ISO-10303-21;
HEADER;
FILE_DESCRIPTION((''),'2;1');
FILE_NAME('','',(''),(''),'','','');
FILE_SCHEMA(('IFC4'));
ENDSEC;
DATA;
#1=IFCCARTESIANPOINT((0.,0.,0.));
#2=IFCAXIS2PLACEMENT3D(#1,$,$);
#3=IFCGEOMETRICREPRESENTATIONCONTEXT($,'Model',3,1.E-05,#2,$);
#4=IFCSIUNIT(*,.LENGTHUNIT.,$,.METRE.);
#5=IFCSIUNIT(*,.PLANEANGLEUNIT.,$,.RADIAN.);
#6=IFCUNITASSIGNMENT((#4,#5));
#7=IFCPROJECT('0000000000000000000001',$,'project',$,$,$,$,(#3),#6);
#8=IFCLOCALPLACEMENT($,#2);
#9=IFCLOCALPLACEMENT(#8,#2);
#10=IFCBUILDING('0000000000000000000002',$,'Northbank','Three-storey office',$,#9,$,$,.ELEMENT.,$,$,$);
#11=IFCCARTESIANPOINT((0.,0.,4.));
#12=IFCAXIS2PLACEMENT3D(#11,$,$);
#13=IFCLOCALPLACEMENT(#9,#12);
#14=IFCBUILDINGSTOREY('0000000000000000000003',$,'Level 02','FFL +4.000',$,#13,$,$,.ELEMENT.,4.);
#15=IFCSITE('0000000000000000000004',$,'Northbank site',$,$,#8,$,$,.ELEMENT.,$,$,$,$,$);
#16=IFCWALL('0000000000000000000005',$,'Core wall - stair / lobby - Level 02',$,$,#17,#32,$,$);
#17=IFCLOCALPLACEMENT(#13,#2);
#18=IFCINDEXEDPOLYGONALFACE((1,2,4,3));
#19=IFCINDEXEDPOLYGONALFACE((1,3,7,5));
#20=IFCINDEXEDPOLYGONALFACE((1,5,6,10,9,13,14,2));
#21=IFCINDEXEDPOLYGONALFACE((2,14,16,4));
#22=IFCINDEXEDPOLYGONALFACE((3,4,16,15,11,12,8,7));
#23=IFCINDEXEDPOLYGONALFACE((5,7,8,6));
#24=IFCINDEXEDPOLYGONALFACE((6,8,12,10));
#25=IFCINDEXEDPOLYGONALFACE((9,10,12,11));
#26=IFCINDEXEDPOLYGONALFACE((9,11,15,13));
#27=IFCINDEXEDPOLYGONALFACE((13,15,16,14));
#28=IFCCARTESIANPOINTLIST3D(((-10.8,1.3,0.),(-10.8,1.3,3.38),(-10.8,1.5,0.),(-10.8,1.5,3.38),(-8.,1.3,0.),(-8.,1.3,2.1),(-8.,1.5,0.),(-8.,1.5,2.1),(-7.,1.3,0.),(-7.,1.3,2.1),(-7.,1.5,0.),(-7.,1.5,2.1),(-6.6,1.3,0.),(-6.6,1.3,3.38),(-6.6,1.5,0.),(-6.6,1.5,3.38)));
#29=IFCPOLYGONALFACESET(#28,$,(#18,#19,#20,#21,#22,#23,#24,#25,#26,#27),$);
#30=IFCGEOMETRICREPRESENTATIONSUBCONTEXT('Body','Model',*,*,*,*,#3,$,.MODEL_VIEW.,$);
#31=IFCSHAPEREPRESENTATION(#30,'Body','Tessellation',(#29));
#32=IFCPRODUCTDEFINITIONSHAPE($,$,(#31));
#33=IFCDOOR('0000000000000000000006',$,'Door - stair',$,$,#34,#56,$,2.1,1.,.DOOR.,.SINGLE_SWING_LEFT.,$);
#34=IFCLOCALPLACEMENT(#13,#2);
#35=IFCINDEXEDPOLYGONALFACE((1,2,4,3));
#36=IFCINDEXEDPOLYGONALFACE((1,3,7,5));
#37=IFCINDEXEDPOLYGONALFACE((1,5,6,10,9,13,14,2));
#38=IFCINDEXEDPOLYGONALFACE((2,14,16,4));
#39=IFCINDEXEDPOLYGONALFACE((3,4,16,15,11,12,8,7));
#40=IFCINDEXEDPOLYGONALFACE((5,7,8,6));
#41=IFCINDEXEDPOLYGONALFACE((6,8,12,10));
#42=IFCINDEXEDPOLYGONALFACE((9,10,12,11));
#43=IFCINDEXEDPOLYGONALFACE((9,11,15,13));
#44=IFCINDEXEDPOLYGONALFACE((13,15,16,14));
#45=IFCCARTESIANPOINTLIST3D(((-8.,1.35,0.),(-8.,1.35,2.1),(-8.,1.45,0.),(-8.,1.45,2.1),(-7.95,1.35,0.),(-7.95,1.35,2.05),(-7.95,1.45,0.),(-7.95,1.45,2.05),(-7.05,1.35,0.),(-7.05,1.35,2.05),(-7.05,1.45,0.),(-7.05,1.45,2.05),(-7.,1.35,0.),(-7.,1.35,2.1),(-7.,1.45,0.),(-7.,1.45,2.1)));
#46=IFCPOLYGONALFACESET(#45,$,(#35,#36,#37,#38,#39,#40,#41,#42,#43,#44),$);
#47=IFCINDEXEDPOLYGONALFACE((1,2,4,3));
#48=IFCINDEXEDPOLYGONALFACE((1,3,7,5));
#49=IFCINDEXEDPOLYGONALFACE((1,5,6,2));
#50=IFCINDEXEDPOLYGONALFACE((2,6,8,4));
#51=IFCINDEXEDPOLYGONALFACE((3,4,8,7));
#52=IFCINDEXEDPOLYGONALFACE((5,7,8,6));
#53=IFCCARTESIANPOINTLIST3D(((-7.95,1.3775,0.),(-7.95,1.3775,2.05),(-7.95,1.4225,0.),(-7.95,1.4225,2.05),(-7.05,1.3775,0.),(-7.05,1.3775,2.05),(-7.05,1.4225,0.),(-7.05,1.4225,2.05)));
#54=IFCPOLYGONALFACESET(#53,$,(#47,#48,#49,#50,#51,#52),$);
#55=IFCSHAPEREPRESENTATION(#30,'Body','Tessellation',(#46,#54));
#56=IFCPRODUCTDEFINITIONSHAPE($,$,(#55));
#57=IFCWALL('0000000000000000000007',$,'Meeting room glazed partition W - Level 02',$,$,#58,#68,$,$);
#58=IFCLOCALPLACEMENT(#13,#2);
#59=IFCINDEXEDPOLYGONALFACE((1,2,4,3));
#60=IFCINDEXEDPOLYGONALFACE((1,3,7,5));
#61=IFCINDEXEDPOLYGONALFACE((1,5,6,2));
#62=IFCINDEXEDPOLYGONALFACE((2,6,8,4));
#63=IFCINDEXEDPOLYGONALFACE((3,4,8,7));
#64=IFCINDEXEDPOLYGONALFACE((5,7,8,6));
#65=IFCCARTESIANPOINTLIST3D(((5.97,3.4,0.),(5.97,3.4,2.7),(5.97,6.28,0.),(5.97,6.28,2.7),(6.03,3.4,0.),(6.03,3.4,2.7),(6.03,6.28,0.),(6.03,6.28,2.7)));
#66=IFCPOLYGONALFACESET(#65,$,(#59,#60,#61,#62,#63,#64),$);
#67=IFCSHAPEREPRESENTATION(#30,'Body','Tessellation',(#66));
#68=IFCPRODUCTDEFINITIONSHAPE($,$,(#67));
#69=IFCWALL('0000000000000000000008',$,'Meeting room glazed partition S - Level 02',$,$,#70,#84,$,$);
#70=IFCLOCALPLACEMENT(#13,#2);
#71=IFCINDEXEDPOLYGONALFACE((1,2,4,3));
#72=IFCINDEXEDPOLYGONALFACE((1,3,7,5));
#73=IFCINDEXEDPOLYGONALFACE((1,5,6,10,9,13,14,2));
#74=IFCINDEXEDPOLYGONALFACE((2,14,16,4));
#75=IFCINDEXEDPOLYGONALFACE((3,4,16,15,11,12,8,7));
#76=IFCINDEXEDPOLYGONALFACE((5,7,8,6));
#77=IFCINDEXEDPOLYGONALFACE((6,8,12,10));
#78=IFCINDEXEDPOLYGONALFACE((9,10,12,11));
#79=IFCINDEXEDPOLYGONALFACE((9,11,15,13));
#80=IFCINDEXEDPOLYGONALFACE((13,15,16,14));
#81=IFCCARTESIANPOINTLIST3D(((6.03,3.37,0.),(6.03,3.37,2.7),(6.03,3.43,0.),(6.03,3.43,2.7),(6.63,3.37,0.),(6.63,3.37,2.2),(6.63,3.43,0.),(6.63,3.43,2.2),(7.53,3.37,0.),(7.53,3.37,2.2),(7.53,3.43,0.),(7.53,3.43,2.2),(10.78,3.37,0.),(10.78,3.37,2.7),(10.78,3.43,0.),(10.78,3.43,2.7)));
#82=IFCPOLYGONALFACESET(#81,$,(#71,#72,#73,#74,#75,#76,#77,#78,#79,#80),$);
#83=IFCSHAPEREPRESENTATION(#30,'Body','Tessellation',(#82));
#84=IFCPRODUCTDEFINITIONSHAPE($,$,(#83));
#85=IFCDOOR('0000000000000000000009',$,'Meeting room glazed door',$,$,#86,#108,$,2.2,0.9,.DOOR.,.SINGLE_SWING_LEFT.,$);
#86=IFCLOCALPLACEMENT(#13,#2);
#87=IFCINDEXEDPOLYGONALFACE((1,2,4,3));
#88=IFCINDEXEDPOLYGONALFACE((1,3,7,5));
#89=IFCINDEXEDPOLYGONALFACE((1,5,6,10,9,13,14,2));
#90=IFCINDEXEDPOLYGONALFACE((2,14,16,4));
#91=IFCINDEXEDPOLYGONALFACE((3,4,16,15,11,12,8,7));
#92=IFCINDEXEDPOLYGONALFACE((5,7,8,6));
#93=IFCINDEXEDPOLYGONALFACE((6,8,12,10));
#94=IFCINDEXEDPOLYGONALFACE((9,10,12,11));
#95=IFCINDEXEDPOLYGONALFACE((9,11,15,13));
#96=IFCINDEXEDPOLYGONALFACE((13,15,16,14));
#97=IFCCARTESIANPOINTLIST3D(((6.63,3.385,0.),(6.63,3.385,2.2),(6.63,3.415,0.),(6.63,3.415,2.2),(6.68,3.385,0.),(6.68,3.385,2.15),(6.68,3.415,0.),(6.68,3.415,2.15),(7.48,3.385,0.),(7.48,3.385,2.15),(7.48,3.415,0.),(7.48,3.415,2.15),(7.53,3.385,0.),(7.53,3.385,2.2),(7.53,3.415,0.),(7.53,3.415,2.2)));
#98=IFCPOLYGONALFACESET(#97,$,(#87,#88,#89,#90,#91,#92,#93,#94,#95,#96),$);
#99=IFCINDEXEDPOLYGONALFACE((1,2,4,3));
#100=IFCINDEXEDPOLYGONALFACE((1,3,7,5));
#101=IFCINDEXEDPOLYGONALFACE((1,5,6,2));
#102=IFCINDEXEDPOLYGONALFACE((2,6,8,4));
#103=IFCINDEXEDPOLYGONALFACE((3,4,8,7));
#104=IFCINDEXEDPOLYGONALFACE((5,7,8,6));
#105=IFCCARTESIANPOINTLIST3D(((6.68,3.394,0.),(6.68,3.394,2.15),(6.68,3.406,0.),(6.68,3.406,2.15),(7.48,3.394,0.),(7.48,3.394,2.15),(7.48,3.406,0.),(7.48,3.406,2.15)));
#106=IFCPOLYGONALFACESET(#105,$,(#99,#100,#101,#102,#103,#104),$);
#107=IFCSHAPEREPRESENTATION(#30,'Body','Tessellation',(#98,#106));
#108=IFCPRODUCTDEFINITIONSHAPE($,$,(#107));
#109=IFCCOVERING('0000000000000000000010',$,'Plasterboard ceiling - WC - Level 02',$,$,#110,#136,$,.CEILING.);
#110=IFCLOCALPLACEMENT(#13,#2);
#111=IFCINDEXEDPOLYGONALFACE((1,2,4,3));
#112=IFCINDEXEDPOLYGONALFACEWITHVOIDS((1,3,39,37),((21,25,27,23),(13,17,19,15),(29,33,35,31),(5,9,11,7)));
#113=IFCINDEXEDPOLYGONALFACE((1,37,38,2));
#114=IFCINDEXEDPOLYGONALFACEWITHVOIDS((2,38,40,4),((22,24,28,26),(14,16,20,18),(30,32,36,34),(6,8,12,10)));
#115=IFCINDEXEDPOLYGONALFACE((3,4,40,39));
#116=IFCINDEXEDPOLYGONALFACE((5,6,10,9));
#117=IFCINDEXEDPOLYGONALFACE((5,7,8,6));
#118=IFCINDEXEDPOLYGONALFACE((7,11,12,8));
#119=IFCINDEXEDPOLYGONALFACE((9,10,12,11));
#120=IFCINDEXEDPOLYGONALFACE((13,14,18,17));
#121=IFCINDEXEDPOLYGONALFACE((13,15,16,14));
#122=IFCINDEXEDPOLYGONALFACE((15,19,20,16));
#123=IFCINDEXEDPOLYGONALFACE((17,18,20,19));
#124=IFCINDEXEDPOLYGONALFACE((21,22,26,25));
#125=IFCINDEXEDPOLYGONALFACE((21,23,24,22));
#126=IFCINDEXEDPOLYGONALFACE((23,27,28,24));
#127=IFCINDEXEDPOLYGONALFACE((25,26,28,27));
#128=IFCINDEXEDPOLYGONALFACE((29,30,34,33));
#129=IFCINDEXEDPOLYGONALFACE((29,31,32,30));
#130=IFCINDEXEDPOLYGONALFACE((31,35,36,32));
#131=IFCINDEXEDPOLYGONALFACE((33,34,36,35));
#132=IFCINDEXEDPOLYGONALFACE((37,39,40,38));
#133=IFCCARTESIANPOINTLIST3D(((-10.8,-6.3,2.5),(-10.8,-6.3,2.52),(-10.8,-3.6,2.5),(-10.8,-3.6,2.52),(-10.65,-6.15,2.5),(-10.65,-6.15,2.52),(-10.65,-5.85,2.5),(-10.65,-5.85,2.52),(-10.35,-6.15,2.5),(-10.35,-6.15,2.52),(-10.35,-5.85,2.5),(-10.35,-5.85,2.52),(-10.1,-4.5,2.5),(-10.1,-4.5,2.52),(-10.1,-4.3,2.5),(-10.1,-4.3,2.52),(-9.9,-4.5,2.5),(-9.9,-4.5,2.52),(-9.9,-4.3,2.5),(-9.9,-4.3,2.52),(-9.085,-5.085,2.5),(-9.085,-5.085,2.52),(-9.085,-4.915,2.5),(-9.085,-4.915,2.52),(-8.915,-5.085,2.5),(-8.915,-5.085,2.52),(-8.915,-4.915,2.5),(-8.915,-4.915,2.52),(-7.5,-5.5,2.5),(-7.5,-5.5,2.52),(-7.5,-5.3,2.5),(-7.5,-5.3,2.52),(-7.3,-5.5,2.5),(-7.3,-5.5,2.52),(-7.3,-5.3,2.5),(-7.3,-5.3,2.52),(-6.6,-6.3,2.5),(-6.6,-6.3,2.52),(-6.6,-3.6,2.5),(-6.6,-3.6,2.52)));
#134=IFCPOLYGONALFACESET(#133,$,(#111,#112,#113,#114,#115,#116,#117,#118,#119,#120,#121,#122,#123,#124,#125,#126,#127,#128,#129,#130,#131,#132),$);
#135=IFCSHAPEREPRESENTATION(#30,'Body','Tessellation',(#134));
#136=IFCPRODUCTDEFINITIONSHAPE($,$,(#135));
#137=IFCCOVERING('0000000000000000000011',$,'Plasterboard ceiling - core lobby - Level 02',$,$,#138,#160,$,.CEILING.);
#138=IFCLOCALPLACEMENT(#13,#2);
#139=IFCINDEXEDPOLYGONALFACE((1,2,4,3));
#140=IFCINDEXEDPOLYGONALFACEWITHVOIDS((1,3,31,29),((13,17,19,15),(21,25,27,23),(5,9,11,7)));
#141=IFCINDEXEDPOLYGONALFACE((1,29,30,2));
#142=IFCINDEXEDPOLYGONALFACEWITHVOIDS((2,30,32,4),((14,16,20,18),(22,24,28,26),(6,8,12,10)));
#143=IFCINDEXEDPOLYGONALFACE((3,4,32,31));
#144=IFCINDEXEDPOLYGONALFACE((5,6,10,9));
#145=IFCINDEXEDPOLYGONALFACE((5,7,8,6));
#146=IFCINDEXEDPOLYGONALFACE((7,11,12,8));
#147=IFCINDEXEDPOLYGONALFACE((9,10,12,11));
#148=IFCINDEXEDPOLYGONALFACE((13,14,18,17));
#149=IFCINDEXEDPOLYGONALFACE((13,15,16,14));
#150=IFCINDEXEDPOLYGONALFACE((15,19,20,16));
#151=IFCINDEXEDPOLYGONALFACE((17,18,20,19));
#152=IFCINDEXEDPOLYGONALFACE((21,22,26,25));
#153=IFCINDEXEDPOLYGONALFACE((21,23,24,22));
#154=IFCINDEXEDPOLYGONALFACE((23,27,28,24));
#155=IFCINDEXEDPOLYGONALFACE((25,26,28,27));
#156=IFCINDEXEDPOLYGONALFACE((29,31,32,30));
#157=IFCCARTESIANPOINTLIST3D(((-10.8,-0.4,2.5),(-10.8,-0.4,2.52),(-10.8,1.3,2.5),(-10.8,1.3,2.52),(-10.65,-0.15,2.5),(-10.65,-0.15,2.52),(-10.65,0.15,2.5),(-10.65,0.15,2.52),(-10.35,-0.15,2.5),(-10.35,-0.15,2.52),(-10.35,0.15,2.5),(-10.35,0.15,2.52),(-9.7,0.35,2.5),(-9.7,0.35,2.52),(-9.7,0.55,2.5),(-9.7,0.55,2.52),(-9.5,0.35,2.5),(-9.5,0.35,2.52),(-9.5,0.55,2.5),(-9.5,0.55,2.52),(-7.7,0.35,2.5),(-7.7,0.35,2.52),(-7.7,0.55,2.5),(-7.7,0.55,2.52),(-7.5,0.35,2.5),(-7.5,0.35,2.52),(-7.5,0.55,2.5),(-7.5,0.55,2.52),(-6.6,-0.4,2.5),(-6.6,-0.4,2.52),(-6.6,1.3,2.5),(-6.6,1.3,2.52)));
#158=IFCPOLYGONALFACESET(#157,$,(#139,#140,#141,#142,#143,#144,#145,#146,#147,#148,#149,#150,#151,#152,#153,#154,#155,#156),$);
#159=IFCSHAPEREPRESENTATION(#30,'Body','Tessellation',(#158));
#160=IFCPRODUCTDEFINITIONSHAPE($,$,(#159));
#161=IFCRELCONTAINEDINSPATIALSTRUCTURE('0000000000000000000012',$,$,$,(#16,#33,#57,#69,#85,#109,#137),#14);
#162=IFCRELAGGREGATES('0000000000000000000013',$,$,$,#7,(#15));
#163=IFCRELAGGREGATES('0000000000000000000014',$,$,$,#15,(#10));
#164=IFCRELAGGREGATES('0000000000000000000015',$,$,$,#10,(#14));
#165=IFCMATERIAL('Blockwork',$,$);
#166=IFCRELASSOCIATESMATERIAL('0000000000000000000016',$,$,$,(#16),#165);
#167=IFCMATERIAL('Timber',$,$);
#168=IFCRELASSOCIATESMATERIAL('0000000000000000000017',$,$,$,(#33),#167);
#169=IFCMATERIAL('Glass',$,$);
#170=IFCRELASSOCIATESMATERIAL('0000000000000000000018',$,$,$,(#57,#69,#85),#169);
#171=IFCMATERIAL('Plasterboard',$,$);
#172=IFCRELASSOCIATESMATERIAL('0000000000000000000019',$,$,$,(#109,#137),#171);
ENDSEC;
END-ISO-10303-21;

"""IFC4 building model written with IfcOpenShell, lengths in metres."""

from ifc_helpers import new_model, si_unit, frame, origin, place, context, subcontext, project, spatial, polyline, outline, extrude, material, element, fill, save


model = new_model("IFC4")

# Units and contexts
model_context = context("Model", 3, precision=1e-05, world=origin())
body_context = subcontext(model_context, "Body", "Model", "MODEL_VIEW")
ifc_project = project(units=[si_unit("LENGTHUNIT", "METRE"), si_unit("PLANEANGLEUNIT", "RADIAN")], contexts=[model_context])

# Site, building, storey
site_placement = place(None, origin())
site = spatial("IfcSite", under=ifc_project, at=site_placement, Name="Northbank site", CompositionType="ELEMENT")
building_placement = place(site_placement, origin())
building = spatial("IfcBuilding", under=site, at=building_placement, Name="Northbank", Description="Three-storey office", CompositionType="ELEMENT")
storey_placement = place(building_placement, frame((0.0, 0.0, 4.0)))
storey = spatial("IfcBuildingStorey", under=building, at=storey_placement, Name="Level 02", Description="FFL +4.000", CompositionType="ELEMENT", Elevation=4.0)

# Wall, opening, door
ifc_material_1 = material(Name="Blockwork")
wall_1_placement = place(storey_placement, frame((0.0, 0.0, -4.0)))
wall_1 = element("IfcWall", 1, at=wall_1_placement, inside=storey, material=ifc_material_1, Name="Core wall - stair / lobby - Level 02", context=body_context, shape_type="SweptSolid", body=[
    extrude(outline(polyline([(0.0, 0.0), (2.8, 0.0), (2.8, 2.1), (3.8, 2.1), (3.8, 0.0), (4.2, 0.0), (4.2, 3.38), (0.0, 3.38), (0.0, 0.0)])), frame((-10.8, 1.5, 4.0), z_axis=(0.0, -1.0, 0.0), x_axis=(1.0, 0.0, 0.0)), (0.0, 0.0, 1.0), 0.2),
])
opening_1_placement = place(storey_placement, frame((0.0, 0.0, -4.0)))
opening_1 = element("IfcOpeningElement", 2, at=opening_1_placement, cuts=wall_1, PredefinedType="OPENING", context=body_context, shape_type="SweptSolid", body=[
    extrude(outline(polyline([(0.0, 0.0), (1.0, 0.0), (1.0, 2.1), (0.0, 2.1), (0.0, 0.0)])), frame((-8.0, 1.55, 4.0), z_axis=(0.0, -1.0, 0.0), x_axis=(1.0, 0.0, 0.0)), (0.0, 0.0, 1.0), 0.3),
])
ifc_material_2 = material(Name="Timber")
door_1_placement = place(storey_placement, frame((0.0, 0.0, -4.0)))
door_1 = element("IfcDoor", 3, at=door_1_placement, inside=storey, material=ifc_material_2, Name="Door - stair", OperationType="SINGLE_SWING_LEFT", OverallHeight=2.1, OverallWidth=1.0, PredefinedType="DOOR", context=body_context, shape_type="SweptSolid", body=[
    extrude(outline(polyline([(0.0, 0.0), (0.05, 0.0), (0.05, 2.05), (0.95, 2.05), (0.95, 0.0), (1.0, 0.0), (1.0, 2.1), (0.0, 2.1), (0.0, 0.0)])), frame((-8.0, 1.45, 4.0), z_axis=(0.0, -1.0, 0.0), x_axis=(1.0, 0.0, 0.0)), (0.0, 0.0, 1.0), 0.1),
    extrude(outline(polyline([(0.0, 0.0), (0.9, 0.0), (0.9, 2.05), (0.0, 2.05), (0.0, 0.0)])), frame((-7.95, 1.4225, 4.0), z_axis=(0.0, -1.0, 0.0), x_axis=(1.0, 0.0, 0.0)), (0.0, 0.0, 1.0), 0.045),
])
fill(opening_1, door_1)

# Wall
ifc_material_3 = material(Name="Glass")
wall_2_placement = place(storey_placement, frame((0.0, 0.0, -4.0)))
element("IfcWall", 4, at=wall_2_placement, inside=storey, material=ifc_material_3, Name="Meeting room glazed partition W - Level 02", context=body_context, shape_type="SweptSolid", body=[
    extrude(outline(polyline([(0.0, 0.0), (2.88, 0.0), (2.88, 2.7), (0.0, 2.7), (0.0, 0.0)])), frame((5.97, 3.4, 4.0), z_axis=(1.0, 0.0, 0.0), x_axis=(0.0, 1.0, 0.0)), (0.0, 0.0, 1.0), 0.06),
])

# Wall, opening, door
wall_3_placement = place(storey_placement, frame((0.0, 0.0, -4.0)))
wall_3 = element("IfcWall", 5, at=wall_3_placement, inside=storey, material=ifc_material_3, Name="Meeting room glazed partition S - Level 02", context=body_context, shape_type="SweptSolid", body=[
    extrude(outline(polyline([(0.0, 0.0), (0.6, 0.0), (0.6, 2.2), (1.5, 2.2), (1.5, 0.0), (4.75, 0.0), (4.75, 2.7), (0.0, 2.7), (0.0, 0.0)])), frame((6.03, 3.43, 4.0), z_axis=(0.0, -1.0, 0.0), x_axis=(1.0, 0.0, 0.0)), (0.0, 0.0, 1.0), 0.06),
])
opening_2_placement = place(storey_placement, frame((0.0, 0.0, -4.0)))
opening_2 = element("IfcOpeningElement", 6, at=opening_2_placement, cuts=wall_3, PredefinedType="OPENING", context=body_context, shape_type="SweptSolid", body=[
    extrude(outline(polyline([(0.0, 0.0), (0.9, 0.0), (0.9, 2.2), (0.0, 2.2), (0.0, 0.0)])), frame((6.63, 3.48, 4.0), z_axis=(0.0, -1.0, 0.0), x_axis=(1.0, 0.0, 0.0)), (0.0, 0.0, 1.0), 0.16),
])
door_2_placement = place(storey_placement, frame((0.0, 0.0, -4.0)))
door_2 = element("IfcDoor", 7, at=door_2_placement, inside=storey, material=ifc_material_3, Name="Meeting room glazed door", OperationType="SINGLE_SWING_LEFT", OverallHeight=2.2, OverallWidth=0.9, PredefinedType="DOOR", context=body_context, shape_type="SweptSolid", body=[
    extrude(outline(polyline([(0.0, 0.0), (0.05, 0.0), (0.05, 2.15), (0.85, 2.15), (0.85, 0.0), (0.9, 0.0), (0.9, 2.2), (0.0, 2.2), (0.0, 0.0)])), frame((6.63, 3.415, 4.0), z_axis=(0.0, -1.0, 0.0), x_axis=(1.0, 0.0, 0.0)), (0.0, 0.0, 1.0), 0.03),
    extrude(outline(polyline([(0.0, 0.0), (0.8, 0.0), (0.8, 2.15), (0.0, 2.15), (0.0, 0.0)])), frame((6.68, 3.406, 4.0), z_axis=(0.0, -1.0, 0.0), x_axis=(1.0, 0.0, 0.0)), (0.0, 0.0, 1.0), 0.012),
])
fill(opening_2, door_2)

# Coverings
ifc_material_4 = material(Name="Plasterboard")
covering_1_placement = place(storey_placement, frame((0.0, 0.0, -4.0)))
element("IfcCovering", 8, at=covering_1_placement, inside=storey, material=ifc_material_4, Name="Plasterboard ceiling - WC - Level 02", PredefinedType="CEILING", context=body_context, shape_type="SweptSolid", body=[
    extrude(outline(polyline([(-10.8, -6.3), (-6.6, -6.3), (-6.6, -3.6), (-10.8, -3.6), (-10.8, -6.3)]), holes=[polyline([(-9.085, -5.085), (-9.085, -4.915), (-8.915, -4.915), (-8.915, -5.085), (-9.085, -5.085)]), polyline([(-10.1, -4.5), (-10.1, -4.3), (-9.9, -4.3), (-9.9, -4.5), (-10.1, -4.5)]), polyline([(-7.5, -5.5), (-7.5, -5.3), (-7.3, -5.3), (-7.3, -5.5), (-7.5, -5.5)]), polyline([(-10.65, -6.15), (-10.65, -5.85), (-10.35, -5.85), (-10.35, -6.15), (-10.65, -6.15)])]), frame((0.0, 0.0, 6.5)), (0.0, 0.0, 1.0), 0.02),
])
covering_2_placement = place(storey_placement, frame((0.0, 0.0, -4.0)))
element("IfcCovering", 9, at=covering_2_placement, inside=storey, material=ifc_material_4, Name="Plasterboard ceiling - core lobby - Level 02", PredefinedType="CEILING", context=body_context, shape_type="SweptSolid", body=[
    extrude(outline(polyline([(-10.8, -0.4), (-6.6, -0.4), (-6.6, 1.3), (-10.8, 1.3), (-10.8, -0.4)]), holes=[polyline([(-9.7, 0.35), (-9.7, 0.55), (-9.5, 0.55), (-9.5, 0.35), (-9.7, 0.35)]), polyline([(-7.7, 0.35), (-7.7, 0.55), (-7.5, 0.55), (-7.5, 0.35), (-7.7, 0.35)]), polyline([(-10.65, -0.15), (-10.65, 0.15), (-10.35, 0.15), (-10.35, -0.15), (-10.65, -0.15)])]), frame((0.0, 0.0, 6.5)), (0.0, 0.0, 1.0), 0.02),
])

save(model, "model.ifc")
